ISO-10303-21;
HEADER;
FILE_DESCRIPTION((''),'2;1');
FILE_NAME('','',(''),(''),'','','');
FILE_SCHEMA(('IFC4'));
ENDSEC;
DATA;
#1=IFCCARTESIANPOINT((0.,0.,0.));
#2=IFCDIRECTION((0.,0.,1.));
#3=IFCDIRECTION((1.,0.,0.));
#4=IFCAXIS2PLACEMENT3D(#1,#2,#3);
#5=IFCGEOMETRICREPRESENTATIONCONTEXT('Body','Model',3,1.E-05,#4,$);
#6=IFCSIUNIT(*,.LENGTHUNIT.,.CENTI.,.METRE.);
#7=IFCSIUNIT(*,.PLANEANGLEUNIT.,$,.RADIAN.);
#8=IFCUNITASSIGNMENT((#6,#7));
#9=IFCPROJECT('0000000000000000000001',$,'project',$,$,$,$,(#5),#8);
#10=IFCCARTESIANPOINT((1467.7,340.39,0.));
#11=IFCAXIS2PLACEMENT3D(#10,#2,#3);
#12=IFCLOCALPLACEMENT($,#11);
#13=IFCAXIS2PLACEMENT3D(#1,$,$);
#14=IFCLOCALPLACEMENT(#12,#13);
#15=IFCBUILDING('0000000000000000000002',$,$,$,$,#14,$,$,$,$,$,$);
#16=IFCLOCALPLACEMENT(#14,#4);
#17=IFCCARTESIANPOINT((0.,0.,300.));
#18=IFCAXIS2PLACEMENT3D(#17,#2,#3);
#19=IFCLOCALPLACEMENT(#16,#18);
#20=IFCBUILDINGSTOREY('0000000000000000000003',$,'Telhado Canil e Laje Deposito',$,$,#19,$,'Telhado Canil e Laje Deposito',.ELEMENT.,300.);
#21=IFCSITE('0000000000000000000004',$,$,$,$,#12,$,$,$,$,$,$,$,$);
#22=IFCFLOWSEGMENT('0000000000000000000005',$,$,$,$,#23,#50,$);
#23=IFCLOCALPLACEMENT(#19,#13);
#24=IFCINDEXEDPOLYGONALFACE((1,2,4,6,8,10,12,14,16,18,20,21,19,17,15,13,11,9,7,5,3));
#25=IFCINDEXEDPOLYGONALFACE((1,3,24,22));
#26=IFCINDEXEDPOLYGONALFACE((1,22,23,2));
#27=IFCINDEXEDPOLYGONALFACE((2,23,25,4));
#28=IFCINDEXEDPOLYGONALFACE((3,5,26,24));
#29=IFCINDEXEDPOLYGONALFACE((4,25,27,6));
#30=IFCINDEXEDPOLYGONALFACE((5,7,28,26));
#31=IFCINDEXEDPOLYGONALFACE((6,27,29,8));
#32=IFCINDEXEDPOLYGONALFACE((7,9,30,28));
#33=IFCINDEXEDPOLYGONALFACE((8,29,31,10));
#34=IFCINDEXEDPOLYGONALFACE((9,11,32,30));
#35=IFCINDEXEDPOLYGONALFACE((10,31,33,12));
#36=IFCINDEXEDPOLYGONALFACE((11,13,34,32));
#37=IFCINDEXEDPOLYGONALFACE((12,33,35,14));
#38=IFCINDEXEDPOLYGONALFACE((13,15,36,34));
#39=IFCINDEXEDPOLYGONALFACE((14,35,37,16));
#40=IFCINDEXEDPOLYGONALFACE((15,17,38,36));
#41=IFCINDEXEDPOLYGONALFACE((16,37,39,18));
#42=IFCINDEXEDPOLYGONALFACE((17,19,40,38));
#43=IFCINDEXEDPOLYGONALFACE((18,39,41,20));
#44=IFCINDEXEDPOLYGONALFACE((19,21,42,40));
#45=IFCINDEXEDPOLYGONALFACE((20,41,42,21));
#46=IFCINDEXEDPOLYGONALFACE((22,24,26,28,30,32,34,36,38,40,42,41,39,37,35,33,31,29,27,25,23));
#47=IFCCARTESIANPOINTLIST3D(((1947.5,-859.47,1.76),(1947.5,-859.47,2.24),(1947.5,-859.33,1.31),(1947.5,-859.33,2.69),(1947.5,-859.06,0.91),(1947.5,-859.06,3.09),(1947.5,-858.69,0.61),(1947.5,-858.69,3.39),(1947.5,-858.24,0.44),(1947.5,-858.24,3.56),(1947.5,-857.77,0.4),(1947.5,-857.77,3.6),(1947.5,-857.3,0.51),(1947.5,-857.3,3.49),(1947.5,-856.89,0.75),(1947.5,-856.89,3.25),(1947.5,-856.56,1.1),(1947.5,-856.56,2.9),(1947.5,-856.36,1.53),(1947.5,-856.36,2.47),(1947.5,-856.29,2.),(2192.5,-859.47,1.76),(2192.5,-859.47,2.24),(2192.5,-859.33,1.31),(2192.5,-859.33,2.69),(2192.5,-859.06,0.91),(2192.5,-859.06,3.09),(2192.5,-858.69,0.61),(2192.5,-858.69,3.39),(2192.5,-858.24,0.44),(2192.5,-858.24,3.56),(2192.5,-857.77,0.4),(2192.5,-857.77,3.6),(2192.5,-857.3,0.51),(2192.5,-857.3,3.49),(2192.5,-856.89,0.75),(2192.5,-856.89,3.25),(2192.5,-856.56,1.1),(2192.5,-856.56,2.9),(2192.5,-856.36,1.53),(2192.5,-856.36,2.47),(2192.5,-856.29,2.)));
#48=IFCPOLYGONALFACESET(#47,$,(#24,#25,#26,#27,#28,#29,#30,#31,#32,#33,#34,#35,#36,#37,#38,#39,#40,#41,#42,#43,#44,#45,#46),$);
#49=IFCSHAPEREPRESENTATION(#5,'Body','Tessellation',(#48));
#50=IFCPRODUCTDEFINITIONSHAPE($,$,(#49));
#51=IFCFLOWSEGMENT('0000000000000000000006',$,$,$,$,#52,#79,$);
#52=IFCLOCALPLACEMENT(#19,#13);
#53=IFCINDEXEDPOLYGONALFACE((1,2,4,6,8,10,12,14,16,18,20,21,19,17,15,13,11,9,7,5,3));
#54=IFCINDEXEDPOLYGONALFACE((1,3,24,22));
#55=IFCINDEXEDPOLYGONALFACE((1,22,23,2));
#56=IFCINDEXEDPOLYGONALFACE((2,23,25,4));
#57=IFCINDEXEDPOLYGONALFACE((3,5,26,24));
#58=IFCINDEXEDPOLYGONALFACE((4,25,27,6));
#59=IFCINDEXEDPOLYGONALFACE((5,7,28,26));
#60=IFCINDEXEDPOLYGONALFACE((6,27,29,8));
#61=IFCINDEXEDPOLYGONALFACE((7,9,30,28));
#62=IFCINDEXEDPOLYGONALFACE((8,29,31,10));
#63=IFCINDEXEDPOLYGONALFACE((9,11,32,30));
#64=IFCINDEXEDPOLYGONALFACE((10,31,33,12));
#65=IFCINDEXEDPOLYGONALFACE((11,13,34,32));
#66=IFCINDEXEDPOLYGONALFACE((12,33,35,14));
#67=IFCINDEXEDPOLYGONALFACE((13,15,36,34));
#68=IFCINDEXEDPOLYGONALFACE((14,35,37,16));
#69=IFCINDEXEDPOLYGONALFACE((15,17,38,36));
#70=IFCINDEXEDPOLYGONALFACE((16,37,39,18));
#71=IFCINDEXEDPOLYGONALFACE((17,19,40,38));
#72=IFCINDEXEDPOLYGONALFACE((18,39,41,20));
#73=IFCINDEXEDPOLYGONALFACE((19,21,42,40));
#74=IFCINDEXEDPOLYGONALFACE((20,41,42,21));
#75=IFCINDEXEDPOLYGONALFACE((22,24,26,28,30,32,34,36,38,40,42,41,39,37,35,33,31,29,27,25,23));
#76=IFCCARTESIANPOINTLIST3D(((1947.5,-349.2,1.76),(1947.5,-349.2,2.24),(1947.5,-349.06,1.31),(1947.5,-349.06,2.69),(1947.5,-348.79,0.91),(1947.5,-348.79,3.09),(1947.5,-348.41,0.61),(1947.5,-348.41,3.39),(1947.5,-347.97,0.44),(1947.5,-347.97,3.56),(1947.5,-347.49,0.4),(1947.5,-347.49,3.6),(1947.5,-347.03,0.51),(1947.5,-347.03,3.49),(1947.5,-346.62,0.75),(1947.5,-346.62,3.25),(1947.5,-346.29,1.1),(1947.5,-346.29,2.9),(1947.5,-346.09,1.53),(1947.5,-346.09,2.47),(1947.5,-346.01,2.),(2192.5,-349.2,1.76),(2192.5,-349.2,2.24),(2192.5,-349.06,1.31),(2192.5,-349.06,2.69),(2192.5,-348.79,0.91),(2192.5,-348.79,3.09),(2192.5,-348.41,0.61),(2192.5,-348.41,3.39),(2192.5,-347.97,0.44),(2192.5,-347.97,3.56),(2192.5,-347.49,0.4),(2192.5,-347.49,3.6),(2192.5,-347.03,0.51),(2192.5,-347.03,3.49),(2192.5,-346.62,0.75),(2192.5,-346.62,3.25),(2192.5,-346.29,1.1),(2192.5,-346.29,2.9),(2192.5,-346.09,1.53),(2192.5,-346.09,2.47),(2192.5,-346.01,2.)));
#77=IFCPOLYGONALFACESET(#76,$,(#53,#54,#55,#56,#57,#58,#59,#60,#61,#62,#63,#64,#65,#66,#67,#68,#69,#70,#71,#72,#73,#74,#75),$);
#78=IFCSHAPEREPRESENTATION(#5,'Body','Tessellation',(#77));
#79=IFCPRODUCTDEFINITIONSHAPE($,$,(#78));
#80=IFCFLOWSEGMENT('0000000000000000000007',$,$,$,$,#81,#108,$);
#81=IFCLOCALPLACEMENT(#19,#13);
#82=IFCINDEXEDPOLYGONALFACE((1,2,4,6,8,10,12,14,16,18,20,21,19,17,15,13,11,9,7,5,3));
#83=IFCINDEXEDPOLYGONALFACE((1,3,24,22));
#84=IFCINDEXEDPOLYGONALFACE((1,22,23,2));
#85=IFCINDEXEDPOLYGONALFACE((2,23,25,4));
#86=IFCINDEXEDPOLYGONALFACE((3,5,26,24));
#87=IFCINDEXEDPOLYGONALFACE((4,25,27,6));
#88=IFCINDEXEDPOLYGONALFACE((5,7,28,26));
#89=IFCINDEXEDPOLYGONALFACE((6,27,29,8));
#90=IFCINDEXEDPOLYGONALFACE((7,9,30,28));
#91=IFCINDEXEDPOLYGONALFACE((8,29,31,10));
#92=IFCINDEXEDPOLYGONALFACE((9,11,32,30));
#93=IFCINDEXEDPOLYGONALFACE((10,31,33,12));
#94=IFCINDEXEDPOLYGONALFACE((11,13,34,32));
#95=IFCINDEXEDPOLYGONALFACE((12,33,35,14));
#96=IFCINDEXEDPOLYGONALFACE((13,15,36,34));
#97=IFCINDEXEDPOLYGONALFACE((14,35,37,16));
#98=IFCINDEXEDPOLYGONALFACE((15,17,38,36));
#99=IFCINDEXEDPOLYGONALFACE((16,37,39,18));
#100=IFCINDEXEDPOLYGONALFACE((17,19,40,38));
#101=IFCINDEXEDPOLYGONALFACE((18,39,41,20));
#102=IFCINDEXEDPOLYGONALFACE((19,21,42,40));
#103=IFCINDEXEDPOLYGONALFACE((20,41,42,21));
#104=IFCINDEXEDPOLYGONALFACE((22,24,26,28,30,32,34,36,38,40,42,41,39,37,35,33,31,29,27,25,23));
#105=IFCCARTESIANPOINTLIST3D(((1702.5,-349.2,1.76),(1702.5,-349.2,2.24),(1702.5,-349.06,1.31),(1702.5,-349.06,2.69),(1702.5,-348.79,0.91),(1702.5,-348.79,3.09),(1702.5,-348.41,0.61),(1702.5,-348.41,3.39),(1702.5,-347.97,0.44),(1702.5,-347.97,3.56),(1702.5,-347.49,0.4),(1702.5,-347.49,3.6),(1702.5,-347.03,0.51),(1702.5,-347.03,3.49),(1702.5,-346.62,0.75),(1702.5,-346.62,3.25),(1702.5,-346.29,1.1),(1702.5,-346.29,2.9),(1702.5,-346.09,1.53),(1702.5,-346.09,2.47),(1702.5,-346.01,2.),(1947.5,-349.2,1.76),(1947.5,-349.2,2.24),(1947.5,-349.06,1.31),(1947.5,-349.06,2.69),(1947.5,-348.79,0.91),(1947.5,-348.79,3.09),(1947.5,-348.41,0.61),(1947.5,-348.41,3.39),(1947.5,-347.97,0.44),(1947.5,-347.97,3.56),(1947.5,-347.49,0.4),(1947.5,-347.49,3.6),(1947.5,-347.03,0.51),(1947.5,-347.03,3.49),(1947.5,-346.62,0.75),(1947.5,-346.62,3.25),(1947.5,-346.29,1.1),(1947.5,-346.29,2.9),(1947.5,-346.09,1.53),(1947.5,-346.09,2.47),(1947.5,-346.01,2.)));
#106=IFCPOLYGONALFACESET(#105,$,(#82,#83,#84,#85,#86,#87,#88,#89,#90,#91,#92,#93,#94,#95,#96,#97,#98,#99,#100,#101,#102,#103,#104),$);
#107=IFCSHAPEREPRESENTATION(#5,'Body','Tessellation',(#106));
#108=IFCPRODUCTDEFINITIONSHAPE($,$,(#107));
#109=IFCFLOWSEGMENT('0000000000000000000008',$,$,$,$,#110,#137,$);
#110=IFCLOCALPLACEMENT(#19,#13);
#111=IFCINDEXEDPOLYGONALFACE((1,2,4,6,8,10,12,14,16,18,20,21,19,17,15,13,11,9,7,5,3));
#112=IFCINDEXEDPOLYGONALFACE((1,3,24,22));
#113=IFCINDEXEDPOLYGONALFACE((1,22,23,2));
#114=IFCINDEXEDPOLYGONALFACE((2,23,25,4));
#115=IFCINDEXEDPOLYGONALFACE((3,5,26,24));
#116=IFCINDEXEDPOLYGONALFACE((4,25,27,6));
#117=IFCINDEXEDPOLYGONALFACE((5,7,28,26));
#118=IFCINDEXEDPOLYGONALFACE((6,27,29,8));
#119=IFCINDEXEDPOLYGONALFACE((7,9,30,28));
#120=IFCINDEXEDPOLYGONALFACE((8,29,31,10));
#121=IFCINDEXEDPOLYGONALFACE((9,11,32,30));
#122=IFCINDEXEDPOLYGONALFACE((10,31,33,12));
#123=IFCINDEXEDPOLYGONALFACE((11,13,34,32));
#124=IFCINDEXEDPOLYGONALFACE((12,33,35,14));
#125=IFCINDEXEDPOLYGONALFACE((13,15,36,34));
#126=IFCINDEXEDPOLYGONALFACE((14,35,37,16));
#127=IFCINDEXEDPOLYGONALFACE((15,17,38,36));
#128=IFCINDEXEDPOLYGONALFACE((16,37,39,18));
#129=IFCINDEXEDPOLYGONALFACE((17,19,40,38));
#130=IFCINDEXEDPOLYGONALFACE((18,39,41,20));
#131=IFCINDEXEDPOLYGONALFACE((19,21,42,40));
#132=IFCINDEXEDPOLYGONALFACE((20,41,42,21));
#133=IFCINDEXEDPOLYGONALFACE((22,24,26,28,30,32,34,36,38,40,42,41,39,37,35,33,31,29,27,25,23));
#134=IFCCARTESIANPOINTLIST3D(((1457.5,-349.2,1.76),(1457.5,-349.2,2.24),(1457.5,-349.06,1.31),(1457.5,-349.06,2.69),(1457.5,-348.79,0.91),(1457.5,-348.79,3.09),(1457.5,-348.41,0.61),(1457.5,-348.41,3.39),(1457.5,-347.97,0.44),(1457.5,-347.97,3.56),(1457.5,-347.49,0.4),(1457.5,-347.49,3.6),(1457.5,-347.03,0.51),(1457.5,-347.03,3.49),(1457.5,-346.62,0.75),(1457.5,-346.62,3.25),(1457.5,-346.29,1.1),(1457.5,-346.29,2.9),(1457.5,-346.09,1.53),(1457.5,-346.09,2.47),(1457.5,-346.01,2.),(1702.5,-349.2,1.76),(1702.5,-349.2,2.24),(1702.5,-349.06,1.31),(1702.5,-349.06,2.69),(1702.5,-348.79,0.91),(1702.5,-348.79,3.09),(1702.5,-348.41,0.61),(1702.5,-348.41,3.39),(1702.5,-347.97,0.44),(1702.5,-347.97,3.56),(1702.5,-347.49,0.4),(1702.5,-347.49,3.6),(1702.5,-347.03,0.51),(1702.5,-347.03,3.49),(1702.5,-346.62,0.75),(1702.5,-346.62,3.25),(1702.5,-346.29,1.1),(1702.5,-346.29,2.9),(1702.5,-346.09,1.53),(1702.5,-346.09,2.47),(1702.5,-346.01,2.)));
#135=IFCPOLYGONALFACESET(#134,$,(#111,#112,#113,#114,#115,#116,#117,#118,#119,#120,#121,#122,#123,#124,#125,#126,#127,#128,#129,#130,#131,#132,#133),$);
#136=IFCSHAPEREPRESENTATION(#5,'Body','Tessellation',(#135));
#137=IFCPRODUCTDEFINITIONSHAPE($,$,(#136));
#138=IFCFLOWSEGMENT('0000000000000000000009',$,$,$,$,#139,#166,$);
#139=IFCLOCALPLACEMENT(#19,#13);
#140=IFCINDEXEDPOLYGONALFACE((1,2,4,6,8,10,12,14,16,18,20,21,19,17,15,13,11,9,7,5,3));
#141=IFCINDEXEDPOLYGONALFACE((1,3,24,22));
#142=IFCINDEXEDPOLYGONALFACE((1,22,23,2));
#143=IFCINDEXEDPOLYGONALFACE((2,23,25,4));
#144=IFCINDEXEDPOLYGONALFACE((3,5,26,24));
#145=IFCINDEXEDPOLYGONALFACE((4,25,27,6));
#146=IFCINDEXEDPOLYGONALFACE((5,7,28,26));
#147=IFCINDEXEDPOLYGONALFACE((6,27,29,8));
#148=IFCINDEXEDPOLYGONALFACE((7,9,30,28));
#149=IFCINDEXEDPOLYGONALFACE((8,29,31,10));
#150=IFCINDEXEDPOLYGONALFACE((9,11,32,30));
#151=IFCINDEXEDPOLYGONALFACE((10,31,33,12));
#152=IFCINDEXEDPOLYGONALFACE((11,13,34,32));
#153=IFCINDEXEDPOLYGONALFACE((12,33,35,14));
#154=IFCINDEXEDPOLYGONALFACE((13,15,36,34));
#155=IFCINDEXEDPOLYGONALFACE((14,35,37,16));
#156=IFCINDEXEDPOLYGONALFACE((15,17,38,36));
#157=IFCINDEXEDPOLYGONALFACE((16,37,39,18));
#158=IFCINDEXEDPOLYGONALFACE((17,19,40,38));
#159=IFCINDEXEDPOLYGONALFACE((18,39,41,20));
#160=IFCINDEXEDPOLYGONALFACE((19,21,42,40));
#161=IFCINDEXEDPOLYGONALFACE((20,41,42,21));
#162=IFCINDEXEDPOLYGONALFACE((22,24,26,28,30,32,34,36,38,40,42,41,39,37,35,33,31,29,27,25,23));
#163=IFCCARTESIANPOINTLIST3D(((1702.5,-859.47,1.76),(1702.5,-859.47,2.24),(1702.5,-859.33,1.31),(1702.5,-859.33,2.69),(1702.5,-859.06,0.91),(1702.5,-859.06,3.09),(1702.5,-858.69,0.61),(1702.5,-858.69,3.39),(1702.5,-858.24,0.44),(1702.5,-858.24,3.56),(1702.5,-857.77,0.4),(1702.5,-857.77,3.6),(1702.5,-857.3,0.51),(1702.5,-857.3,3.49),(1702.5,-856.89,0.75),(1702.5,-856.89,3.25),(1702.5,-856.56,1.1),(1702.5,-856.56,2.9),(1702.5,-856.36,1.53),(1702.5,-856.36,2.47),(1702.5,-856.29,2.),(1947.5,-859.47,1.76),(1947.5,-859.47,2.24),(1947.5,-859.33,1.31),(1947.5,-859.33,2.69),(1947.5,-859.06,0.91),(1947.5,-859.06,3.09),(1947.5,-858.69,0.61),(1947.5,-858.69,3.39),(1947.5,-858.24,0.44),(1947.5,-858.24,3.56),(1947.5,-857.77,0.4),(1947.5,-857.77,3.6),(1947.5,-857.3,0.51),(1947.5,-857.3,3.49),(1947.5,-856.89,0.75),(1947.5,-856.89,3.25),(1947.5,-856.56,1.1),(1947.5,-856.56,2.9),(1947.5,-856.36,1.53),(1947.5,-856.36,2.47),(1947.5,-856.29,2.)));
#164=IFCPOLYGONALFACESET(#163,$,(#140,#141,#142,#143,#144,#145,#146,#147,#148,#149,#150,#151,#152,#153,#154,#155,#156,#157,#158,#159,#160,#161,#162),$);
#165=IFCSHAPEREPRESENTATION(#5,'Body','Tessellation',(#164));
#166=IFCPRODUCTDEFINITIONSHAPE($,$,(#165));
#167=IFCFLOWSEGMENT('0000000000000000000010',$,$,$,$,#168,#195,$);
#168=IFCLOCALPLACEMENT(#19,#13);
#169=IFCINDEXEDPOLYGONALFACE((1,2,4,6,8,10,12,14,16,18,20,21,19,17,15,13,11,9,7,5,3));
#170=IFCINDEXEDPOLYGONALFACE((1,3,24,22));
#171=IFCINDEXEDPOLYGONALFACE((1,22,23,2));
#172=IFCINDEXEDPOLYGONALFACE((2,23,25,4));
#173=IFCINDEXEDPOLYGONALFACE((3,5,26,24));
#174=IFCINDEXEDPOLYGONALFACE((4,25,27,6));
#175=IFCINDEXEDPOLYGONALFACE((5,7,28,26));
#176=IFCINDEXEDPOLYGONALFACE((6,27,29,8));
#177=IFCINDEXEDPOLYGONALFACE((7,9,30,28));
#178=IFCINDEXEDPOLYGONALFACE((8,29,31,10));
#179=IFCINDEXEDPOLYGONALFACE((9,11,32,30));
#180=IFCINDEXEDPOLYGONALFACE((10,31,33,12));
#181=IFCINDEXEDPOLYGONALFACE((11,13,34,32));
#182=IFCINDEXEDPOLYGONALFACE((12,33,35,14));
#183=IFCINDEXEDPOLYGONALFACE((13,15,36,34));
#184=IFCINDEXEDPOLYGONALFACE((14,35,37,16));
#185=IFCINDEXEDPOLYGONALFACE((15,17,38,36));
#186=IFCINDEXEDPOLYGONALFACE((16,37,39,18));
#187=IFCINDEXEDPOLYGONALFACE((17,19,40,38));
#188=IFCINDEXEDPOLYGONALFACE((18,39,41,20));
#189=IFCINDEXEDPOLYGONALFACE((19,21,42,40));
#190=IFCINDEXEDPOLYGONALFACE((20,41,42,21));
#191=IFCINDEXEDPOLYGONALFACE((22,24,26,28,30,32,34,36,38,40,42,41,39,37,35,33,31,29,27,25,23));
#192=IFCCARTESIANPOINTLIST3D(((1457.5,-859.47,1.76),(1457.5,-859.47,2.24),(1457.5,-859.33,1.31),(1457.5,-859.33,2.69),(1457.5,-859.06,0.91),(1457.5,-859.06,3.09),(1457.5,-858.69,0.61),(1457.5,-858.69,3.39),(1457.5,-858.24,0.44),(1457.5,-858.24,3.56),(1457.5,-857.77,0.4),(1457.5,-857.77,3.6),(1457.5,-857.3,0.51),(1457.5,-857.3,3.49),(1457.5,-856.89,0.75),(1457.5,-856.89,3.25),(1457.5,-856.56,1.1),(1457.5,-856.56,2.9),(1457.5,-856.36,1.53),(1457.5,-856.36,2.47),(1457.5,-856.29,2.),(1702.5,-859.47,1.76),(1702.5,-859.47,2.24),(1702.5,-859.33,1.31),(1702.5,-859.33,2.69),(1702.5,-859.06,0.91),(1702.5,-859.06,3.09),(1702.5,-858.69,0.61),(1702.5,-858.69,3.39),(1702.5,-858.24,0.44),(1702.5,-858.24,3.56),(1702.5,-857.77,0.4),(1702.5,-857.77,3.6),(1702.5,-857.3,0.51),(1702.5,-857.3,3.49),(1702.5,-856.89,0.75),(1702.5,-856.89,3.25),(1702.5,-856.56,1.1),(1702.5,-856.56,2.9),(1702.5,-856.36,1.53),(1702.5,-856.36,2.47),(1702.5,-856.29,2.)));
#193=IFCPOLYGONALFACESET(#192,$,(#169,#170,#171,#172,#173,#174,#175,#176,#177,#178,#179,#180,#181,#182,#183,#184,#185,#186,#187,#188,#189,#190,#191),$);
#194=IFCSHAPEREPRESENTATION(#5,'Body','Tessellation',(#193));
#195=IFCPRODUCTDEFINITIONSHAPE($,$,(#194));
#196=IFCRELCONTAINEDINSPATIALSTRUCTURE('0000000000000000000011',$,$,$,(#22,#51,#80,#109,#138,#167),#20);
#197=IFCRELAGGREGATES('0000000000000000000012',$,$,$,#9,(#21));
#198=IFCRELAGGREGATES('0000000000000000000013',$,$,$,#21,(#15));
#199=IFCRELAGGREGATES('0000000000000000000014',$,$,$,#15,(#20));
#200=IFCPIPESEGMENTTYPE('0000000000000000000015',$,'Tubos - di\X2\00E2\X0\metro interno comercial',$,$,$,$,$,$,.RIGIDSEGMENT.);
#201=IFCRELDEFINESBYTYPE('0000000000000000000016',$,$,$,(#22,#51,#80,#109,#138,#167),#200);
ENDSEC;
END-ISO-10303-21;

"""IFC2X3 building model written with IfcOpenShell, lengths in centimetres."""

from ifc_helpers import new_model, si_unit, frame, origin, origin_with_axes, origin_2d_with_axis, place, context, project, spatial, circle, extrude, type_object, element, save


model = new_model("IFC2X3")

# Units and contexts
model_context = context("Model", 3, precision=1e-05, world=origin_with_axes(), identifier="Body")
ifc_project = project(units=[si_unit("LENGTHUNIT", "METRE", prefix="CENTI"), si_unit("PLANEANGLEUNIT", "RADIAN")], contexts=[model_context])

# Site, building, storey
site_placement = place(None, frame((1467.7, 340.39, 0.0), z_axis=(0.0, 0.0, 1.0), x_axis=(1.0, 0.0, 0.0)))
site = spatial("IfcSite", under=ifc_project, at=site_placement)
building_placement = place(site_placement, origin())
building = spatial("IfcBuilding", under=site, at=building_placement)
placement = place(building_placement, origin_with_axes())
storey_placement = place(placement, frame((0.0, 0.0, 300.0), z_axis=(0.0, 0.0, 1.0), x_axis=(1.0, 0.0, 0.0)))
storey = spatial("IfcBuildingStorey", under=building, at=storey_placement, Name="Telhado Canil e Laje Deposito", LongName="Telhado Canil e Laje Deposito", CompositionType="ELEMENT", Elevation=300.0)

# Flow segments
pipe_segment_type = type_object("IfcPipeSegmentType", Name="Tubos - diâmetro interno comercial", PredefinedType="RIGIDSEGMENT")
for number, where, z_axis, x_axis in (
    (1, (2070.0, -857.89, 3.6), (0.0, 0.0, 1.0), (1.0, 0.0, 0.0)),
    (2, (2070.0, -347.61, 3.6), (0.0, 0.0, 1.0), (1.0, 0.0, 0.0)),
    (3, (1825.0, -347.61, 3.6), (0.0, 0.0, 1.0), (1.0, 0.0, 0.0)),
    (4, (1580.0, -347.61, 3.6), (0.0, 0.0, 1.0), (1.0, 0.0, 0.0)),
    (5, (1825.0, -857.89, 3.6), (0.0, 0.0, 1.0), (1.0, 0.0, 0.0)),
    (6, (1580.0, -857.89, 3.6), (0.0, 0.0, 1.0), (1.0, 0.0, 0.0)),
):
    element("IfcFlowSegment", number, at=place(storey_placement, frame(where, z_axis=z_axis, x_axis=x_axis)), inside=storey, type_object=pipe_segment_type, context=model_context, shape_type="SolidModel", body=[
        extrude(circle(Radius=1.6, at=origin_2d_with_axis()), frame((122.5, 0.0, -1.6), z_axis=(-1.0, 0.0, 0.0), x_axis=(0.0, 1.0, 0.0)), (0.0, 0.0, 1.0), 245.0),
    ])

save(model, "model.ifc")
